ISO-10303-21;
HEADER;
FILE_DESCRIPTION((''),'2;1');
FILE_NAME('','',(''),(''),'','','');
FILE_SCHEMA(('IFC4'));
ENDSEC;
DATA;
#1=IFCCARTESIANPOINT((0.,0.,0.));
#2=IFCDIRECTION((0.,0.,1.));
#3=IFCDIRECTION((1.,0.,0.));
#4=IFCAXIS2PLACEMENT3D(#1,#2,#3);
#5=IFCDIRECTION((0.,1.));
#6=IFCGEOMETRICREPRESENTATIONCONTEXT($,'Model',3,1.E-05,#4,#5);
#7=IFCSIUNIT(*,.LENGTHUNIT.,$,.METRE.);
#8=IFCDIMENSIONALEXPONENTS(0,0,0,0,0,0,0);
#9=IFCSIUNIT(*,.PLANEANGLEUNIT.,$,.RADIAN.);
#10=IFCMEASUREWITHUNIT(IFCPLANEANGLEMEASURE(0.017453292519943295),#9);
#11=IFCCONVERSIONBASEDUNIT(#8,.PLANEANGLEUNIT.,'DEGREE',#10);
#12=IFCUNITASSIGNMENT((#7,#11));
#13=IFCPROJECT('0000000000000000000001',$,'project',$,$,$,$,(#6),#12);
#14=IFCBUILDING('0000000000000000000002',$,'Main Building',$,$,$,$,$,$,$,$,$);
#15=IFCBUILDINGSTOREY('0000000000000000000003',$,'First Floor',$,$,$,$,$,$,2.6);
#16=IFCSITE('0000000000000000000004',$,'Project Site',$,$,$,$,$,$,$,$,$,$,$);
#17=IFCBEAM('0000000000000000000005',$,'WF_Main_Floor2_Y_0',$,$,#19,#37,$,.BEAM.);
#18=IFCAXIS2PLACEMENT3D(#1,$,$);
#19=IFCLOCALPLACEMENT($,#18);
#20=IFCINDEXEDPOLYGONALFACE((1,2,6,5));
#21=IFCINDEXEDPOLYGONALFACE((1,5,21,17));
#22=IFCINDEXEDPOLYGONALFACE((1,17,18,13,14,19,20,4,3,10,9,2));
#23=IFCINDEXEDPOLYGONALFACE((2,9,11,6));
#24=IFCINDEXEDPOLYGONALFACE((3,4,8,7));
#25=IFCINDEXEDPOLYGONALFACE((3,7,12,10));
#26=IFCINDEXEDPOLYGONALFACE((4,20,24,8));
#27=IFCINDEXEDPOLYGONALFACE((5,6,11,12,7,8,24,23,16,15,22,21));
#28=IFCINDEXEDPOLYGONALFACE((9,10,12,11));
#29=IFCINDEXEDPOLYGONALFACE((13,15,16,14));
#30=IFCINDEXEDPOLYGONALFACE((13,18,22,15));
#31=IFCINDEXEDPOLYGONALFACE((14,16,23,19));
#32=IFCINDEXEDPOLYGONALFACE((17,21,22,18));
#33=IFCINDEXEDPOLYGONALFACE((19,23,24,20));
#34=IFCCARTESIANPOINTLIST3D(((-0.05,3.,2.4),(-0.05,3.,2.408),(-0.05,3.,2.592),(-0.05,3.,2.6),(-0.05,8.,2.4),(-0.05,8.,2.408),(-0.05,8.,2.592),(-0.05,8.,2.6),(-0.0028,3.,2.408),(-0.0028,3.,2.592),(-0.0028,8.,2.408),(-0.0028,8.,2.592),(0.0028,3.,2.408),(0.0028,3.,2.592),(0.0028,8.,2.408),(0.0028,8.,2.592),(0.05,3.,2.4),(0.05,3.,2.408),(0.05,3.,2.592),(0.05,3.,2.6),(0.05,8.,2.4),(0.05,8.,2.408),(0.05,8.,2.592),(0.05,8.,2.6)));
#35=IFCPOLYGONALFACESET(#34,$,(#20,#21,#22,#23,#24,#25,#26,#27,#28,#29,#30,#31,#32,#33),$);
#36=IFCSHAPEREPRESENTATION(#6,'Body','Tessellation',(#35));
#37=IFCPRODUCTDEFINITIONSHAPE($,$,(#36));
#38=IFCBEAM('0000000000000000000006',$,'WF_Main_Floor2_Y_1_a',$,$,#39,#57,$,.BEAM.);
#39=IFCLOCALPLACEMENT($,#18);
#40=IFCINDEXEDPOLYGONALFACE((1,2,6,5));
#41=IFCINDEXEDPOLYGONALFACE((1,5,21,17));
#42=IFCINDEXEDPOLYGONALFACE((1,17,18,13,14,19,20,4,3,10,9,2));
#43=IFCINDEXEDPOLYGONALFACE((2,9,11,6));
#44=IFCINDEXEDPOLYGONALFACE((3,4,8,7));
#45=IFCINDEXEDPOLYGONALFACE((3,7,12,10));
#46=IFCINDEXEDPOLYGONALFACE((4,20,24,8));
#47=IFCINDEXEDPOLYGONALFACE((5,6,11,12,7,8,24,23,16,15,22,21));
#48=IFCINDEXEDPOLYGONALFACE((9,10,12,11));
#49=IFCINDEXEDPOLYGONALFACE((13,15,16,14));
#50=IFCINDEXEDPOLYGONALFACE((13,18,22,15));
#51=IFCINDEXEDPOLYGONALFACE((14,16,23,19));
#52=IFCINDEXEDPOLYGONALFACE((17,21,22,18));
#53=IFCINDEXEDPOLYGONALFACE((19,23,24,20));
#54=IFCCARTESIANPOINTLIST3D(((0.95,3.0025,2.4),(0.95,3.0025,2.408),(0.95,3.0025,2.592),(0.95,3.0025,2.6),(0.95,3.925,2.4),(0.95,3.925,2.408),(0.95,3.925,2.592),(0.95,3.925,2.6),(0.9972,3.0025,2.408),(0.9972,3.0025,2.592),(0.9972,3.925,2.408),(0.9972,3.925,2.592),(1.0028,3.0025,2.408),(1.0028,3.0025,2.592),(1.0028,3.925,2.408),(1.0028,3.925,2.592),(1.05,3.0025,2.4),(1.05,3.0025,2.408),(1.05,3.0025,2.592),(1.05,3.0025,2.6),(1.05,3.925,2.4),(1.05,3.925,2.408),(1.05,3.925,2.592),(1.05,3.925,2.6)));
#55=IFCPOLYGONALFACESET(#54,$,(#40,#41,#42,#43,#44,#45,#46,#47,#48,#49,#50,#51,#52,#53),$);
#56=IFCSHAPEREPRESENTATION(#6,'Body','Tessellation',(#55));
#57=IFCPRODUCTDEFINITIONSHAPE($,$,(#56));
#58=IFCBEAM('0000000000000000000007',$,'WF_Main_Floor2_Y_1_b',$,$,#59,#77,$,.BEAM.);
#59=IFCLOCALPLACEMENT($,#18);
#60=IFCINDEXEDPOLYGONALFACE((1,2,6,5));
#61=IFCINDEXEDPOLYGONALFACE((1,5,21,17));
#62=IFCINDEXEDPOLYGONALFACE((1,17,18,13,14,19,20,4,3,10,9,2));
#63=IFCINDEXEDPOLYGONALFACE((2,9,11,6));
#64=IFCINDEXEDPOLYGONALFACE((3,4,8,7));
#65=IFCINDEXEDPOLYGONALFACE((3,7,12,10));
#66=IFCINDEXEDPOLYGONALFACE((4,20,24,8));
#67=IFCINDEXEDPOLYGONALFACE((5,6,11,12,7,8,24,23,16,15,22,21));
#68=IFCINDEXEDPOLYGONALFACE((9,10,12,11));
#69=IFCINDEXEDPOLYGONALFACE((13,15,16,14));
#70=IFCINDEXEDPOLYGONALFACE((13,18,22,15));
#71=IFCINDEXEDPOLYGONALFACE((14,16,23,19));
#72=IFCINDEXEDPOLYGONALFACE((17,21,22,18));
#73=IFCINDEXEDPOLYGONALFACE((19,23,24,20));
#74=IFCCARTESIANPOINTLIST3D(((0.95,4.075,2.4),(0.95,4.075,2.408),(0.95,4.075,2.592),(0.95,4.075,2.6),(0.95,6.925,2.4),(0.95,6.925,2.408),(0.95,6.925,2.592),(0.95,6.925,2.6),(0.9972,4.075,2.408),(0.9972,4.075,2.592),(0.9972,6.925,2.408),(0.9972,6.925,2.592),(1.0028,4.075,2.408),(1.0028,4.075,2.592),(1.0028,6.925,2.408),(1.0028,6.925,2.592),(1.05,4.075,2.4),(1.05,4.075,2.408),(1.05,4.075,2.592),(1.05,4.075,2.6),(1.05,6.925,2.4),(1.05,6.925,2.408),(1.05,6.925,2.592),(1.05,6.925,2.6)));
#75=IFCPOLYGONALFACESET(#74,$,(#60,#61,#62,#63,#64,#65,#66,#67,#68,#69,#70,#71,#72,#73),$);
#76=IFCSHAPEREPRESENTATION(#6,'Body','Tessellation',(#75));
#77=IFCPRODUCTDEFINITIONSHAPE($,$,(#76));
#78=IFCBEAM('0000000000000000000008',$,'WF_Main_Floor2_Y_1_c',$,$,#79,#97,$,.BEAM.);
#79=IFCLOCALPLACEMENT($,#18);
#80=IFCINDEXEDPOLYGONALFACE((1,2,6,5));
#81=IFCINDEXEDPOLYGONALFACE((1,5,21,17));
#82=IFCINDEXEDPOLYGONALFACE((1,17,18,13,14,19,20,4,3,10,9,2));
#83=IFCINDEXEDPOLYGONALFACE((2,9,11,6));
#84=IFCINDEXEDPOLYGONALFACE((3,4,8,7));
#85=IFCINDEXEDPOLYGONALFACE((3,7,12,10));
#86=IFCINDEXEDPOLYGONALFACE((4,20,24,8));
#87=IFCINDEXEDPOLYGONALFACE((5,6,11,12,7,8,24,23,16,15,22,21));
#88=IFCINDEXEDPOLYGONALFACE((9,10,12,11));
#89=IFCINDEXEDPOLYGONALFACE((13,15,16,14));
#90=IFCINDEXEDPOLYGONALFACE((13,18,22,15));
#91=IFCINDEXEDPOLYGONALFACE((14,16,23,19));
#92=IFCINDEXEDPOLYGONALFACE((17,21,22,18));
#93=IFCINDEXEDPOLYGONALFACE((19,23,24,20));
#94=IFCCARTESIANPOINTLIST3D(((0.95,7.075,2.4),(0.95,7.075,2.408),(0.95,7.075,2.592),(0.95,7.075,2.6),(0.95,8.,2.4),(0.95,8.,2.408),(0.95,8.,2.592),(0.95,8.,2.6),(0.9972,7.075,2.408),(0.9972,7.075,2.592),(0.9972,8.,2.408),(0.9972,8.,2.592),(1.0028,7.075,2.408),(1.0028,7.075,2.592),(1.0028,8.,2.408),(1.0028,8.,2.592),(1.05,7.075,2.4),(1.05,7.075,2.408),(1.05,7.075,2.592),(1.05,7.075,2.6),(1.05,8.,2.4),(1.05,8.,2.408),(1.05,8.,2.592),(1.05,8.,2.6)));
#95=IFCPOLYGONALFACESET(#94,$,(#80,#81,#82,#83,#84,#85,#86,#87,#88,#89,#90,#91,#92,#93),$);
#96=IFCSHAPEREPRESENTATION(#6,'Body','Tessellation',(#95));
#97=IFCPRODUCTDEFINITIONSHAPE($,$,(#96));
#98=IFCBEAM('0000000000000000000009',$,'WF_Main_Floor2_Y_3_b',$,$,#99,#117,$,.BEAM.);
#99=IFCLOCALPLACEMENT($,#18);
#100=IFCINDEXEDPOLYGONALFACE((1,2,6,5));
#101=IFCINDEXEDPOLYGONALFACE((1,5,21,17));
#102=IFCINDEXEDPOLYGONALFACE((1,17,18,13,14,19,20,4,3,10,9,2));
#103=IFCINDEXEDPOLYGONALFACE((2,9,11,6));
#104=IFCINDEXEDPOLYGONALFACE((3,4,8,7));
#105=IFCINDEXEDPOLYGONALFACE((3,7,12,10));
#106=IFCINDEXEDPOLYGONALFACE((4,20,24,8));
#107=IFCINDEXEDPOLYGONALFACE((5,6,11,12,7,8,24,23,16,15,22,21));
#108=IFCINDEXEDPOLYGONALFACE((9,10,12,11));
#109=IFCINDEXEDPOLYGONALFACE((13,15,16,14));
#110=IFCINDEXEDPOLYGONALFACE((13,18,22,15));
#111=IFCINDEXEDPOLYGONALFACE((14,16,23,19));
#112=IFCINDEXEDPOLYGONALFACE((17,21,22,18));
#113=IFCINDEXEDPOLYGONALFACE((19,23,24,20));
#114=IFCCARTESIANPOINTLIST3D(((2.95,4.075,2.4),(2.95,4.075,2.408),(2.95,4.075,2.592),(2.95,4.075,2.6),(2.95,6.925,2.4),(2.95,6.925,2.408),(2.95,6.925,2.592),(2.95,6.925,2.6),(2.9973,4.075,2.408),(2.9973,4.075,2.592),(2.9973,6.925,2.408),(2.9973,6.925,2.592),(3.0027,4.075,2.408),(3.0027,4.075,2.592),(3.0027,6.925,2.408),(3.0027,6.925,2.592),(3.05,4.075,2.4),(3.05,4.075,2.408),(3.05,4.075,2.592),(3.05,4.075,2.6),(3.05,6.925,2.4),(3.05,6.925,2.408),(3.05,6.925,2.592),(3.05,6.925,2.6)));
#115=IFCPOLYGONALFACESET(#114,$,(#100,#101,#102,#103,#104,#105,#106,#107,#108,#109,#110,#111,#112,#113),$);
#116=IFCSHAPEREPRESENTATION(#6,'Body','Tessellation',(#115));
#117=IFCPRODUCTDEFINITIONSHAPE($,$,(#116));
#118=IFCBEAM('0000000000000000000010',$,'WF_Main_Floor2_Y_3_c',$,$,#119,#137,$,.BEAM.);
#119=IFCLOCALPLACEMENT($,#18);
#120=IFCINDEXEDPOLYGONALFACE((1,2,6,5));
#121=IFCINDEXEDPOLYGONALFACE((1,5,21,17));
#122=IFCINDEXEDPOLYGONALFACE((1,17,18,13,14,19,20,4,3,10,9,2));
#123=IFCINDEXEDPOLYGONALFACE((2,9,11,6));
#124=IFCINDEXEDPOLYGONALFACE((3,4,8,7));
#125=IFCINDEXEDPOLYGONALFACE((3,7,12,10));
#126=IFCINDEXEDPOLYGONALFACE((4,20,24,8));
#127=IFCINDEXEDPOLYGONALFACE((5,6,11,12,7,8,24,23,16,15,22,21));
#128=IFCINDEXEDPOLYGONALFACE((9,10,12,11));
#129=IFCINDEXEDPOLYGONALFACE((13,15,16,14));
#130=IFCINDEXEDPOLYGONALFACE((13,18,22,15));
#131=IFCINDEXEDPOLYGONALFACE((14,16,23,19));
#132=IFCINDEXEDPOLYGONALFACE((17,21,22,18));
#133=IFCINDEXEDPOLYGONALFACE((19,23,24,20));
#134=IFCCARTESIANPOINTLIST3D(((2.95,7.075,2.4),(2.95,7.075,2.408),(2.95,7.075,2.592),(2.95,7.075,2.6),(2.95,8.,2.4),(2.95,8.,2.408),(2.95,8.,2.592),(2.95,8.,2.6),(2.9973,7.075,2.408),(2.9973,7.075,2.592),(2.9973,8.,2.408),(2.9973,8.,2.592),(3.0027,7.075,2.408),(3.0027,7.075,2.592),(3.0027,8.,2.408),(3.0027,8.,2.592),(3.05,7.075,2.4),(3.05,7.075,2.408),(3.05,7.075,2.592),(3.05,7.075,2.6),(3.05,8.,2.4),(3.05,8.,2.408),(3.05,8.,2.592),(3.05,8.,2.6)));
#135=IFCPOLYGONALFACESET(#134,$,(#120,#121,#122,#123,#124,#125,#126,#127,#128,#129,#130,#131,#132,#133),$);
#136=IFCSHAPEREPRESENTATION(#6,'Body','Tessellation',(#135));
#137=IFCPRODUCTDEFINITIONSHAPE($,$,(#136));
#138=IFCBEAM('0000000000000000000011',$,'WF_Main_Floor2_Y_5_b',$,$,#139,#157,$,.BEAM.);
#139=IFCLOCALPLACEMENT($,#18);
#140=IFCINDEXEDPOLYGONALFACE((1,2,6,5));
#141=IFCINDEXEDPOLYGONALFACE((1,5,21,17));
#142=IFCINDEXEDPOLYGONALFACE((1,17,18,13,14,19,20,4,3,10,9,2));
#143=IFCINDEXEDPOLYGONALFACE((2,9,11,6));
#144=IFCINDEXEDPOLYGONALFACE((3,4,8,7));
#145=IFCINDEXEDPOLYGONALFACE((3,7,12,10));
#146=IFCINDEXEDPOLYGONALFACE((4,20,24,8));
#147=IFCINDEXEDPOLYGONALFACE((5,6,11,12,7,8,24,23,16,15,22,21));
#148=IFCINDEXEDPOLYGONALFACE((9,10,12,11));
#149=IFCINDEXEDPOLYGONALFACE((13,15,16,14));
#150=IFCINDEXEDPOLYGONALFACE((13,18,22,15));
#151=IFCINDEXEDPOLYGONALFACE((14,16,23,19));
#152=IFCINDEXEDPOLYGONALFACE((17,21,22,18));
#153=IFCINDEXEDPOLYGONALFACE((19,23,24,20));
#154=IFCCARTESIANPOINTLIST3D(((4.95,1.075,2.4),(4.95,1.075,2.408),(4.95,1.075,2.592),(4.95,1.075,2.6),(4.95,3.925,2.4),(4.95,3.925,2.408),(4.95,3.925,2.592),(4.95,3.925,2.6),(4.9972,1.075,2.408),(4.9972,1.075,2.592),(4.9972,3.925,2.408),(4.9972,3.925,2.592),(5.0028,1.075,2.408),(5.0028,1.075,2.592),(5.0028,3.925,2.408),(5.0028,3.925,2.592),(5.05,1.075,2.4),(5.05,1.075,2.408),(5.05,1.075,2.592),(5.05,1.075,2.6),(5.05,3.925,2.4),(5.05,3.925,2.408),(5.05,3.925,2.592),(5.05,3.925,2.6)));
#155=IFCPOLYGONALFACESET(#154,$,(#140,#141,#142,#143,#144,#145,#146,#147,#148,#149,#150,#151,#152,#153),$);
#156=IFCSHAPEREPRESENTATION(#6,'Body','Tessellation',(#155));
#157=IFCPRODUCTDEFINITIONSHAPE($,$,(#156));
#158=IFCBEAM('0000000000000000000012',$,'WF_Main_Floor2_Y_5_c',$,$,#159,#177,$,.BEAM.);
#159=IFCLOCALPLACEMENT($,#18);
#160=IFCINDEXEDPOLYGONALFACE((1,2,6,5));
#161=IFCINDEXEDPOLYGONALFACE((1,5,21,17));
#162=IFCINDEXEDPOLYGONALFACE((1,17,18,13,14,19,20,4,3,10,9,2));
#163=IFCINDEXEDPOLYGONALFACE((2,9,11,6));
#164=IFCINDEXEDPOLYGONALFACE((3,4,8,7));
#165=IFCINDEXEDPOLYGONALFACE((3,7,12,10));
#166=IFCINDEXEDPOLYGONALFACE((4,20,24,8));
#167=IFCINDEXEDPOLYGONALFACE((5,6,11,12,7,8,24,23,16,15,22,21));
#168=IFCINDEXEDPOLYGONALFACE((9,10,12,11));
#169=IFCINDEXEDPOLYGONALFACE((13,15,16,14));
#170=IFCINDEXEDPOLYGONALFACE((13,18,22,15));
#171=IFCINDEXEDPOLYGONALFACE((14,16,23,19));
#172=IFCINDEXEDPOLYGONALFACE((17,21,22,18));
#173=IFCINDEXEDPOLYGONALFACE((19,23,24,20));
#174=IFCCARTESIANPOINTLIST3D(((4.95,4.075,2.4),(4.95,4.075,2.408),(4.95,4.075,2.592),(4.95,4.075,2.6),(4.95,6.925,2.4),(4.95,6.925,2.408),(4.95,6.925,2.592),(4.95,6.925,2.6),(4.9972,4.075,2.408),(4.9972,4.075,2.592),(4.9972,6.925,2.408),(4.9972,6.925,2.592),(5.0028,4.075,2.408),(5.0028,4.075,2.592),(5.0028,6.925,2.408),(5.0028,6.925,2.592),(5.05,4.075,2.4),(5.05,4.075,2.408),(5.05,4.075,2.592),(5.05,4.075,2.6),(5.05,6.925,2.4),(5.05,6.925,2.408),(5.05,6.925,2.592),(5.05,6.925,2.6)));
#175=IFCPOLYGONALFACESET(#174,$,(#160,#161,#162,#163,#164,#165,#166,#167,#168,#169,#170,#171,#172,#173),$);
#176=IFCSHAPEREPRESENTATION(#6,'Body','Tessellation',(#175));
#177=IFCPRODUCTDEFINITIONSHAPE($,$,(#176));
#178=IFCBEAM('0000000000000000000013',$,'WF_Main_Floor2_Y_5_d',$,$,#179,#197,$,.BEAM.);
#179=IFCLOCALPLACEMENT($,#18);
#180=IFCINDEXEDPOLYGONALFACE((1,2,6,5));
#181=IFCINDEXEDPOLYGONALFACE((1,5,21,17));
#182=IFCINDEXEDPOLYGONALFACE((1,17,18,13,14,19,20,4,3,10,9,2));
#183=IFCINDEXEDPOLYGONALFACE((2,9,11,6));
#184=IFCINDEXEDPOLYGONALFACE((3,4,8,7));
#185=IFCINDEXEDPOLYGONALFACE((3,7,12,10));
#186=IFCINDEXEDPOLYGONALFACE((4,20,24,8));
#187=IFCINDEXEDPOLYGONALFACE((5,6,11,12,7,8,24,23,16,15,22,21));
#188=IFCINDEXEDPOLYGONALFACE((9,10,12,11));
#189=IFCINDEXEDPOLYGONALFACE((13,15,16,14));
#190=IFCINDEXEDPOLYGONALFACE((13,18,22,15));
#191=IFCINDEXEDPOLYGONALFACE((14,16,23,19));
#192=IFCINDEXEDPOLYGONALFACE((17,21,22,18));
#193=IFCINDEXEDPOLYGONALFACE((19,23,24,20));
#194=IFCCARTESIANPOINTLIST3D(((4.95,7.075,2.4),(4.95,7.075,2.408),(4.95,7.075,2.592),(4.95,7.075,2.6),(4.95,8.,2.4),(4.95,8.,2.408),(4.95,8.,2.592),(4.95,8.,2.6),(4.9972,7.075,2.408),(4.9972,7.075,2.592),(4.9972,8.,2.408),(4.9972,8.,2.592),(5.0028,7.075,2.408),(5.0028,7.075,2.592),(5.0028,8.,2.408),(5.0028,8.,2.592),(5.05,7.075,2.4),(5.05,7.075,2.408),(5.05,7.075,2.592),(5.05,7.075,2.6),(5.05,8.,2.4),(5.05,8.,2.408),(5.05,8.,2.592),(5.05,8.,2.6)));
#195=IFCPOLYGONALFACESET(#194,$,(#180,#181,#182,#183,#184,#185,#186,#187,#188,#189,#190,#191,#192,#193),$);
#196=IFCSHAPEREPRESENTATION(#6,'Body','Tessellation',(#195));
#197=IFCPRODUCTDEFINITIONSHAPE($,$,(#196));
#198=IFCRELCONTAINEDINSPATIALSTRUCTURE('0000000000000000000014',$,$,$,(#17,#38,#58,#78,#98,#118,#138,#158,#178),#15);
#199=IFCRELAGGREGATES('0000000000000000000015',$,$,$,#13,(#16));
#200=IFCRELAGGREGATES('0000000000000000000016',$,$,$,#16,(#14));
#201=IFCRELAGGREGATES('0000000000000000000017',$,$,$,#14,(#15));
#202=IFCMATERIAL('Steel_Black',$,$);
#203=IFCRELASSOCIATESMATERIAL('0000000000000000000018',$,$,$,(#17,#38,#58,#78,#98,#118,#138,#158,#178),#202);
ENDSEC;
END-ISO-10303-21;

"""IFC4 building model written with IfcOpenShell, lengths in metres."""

from ifc_helpers import new_model, entity, si_unit, converted_unit, direction, frame, frame_2d, origin_with_axes, place, context, project, spatial, i_section, extrude, material, element, save


model = new_model("IFC4")

# Units and contexts
model_context = context("Model", 3, precision=1e-05, world=origin_with_axes(), true_north=direction((0.0, 1.0)))
ifc_project = project(units=[si_unit("LENGTHUNIT", "METRE"), converted_unit("PLANEANGLEUNIT", "DEGREE", entity("IfcPlaneAngleMeasure", 0.017453292519943295), si_unit("PLANEANGLEUNIT", "RADIAN"), dimensions=[0, 0, 0, 0, 0, 0, 0])], contexts=[model_context])

# Site, building, storey
site = spatial("IfcSite", under=ifc_project, Name="Project Site")
building = spatial("IfcBuilding", under=site, Name="Main Building")
storey = spatial("IfcBuildingStorey", under=building, Name="First Floor", Elevation=2.6)

# Shared definitions
ifc_material = material(Name="Steel_Black")

# Beams
beam_1_placement = place(None, frame((0.0, 3.0, 2.4), z_axis=(0.0, 0.0, 1.0), x_axis=(0.0, 1.0, 0.0)))
element("IfcBeam", 1, at=beam_1_placement, inside=storey, material=ifc_material, Name="WF_Main_Floor2_Y_0", PredefinedType="BEAM", context=model_context, shape_type="SweptSolid", body=[
    extrude(i_section(OverallWidth=0.1, OverallDepth=0.2, WebThickness=0.0055, FlangeThickness=0.008, at=frame_2d((0.0, 0.1))), frame((0.0, 0.0, 0.0), z_axis=(1.0, 0.0, 0.0), x_axis=(0.0, 1.0, 0.0)), (0.0, 0.0, 1.0), 5.0),
])
beam_2_placement = place(None, frame((1.0, 3.0025, 2.4), z_axis=(0.0, 0.0, 1.0), x_axis=(0.0, 1.0, 0.0)))
element("IfcBeam", 2, at=beam_2_placement, inside=storey, material=ifc_material, Name="WF_Main_Floor2_Y_1_a", PredefinedType="BEAM", context=model_context, shape_type="SweptSolid", body=[
    extrude(i_section(OverallWidth=0.1, OverallDepth=0.2, WebThickness=0.0055, FlangeThickness=0.008, at=frame_2d((0.0, 0.1))), frame((0.0, 0.0, 0.0), z_axis=(1.0, 0.0, 0.0), x_axis=(0.0, 1.0, 0.0)), (0.0, 0.0, 1.0), 0.9225),
])
beam_3_placement = place(None, frame((1.0, 4.075, 2.4), z_axis=(0.0, 0.0, 1.0), x_axis=(0.0, 1.0, 0.0)))
element("IfcBeam", 3, at=beam_3_placement, inside=storey, material=ifc_material, Name="WF_Main_Floor2_Y_1_b", PredefinedType="BEAM", context=model_context, shape_type="SweptSolid", body=[
    extrude(i_section(OverallWidth=0.1, OverallDepth=0.2, WebThickness=0.0055, FlangeThickness=0.008, at=frame_2d((0.0, 0.1))), frame((0.0, 0.0, 0.0), z_axis=(1.0, 0.0, 0.0), x_axis=(0.0, 1.0, 0.0)), (0.0, 0.0, 1.0), 2.85),
])
beam_4_placement = place(None, frame((1.0, 7.075, 2.4), z_axis=(0.0, 0.0, 1.0), x_axis=(0.0, 1.0, 0.0)))
element("IfcBeam", 4, at=beam_4_placement, inside=storey, material=ifc_material, Name="WF_Main_Floor2_Y_1_c", PredefinedType="BEAM", context=model_context, shape_type="SweptSolid", body=[
    extrude(i_section(OverallWidth=0.1, OverallDepth=0.2, WebThickness=0.0055, FlangeThickness=0.008, at=frame_2d((0.0, 0.1))), frame((0.0, 0.0, 0.0), z_axis=(1.0, 0.0, 0.0), x_axis=(0.0, 1.0, 0.0)), (0.0, 0.0, 1.0), 0.925),
])
beam_5_placement = place(None, frame((3.0, 4.075, 2.4), z_axis=(0.0, 0.0, 1.0), x_axis=(0.0, 1.0, 0.0)))
element("IfcBeam", 5, at=beam_5_placement, inside=storey, material=ifc_material, Name="WF_Main_Floor2_Y_3_b", PredefinedType="BEAM", context=model_context, shape_type="SweptSolid", body=[
    extrude(i_section(OverallWidth=0.1, OverallDepth=0.2, WebThickness=0.0055, FlangeThickness=0.008, at=frame_2d((0.0, 0.1))), frame((0.0, 0.0, 0.0), z_axis=(1.0, 0.0, 0.0), x_axis=(0.0, 1.0, 0.0)), (0.0, 0.0, 1.0), 2.85),
])
beam_6_placement = place(None, frame((3.0, 7.075, 2.4), z_axis=(0.0, 0.0, 1.0), x_axis=(0.0, 1.0, 0.0)))
element("IfcBeam", 6, at=beam_6_placement, inside=storey, material=ifc_material, Name="WF_Main_Floor2_Y_3_c", PredefinedType="BEAM", context=model_context, shape_type="SweptSolid", body=[
    extrude(i_section(OverallWidth=0.1, OverallDepth=0.2, WebThickness=0.0055, FlangeThickness=0.008, at=frame_2d((0.0, 0.1))), frame((0.0, 0.0, 0.0), z_axis=(1.0, 0.0, 0.0), x_axis=(0.0, 1.0, 0.0)), (0.0, 0.0, 1.0), 0.925),
])
for number, where, z_axis, x_axis, name in (
    (7, (5.0, 1.075, 2.4), (0.0, 0.0, 1.0), (0.0, 1.0, 0.0), "WF_Main_Floor2_Y_5_b"),
    (8, (5.0, 4.075, 2.4), (0.0, 0.0, 1.0), (0.0, 1.0, 0.0), "WF_Main_Floor2_Y_5_c"),
):
    element("IfcBeam", number, at=place(None, frame(where, z_axis=z_axis, x_axis=x_axis)), inside=storey, material=ifc_material, Name=name, PredefinedType="BEAM", context=model_context, shape_type="SweptSolid", body=[
        extrude(i_section(OverallWidth=0.1, OverallDepth=0.2, WebThickness=0.0055, FlangeThickness=0.008, at=frame_2d((0.0, 0.1))), frame((0.0, 0.0, 0.0), z_axis=(1.0, 0.0, 0.0), x_axis=(0.0, 1.0, 0.0)), (0.0, 0.0, 1.0), 2.85),
    ])
beam_7_placement = place(None, frame((5.0, 7.075, 2.4), z_axis=(0.0, 0.0, 1.0), x_axis=(0.0, 1.0, 0.0)))
element("IfcBeam", 9, at=beam_7_placement, inside=storey, material=ifc_material, Name="WF_Main_Floor2_Y_5_d", PredefinedType="BEAM", context=model_context, shape_type="SweptSolid", body=[
    extrude(i_section(OverallWidth=0.1, OverallDepth=0.2, WebThickness=0.0055, FlangeThickness=0.008, at=frame_2d((0.0, 0.1))), frame((0.0, 0.0, 0.0), z_axis=(1.0, 0.0, 0.0), x_axis=(0.0, 1.0, 0.0)), (0.0, 0.0, 1.0), 0.925),
])

save(model, "model.ifc")
